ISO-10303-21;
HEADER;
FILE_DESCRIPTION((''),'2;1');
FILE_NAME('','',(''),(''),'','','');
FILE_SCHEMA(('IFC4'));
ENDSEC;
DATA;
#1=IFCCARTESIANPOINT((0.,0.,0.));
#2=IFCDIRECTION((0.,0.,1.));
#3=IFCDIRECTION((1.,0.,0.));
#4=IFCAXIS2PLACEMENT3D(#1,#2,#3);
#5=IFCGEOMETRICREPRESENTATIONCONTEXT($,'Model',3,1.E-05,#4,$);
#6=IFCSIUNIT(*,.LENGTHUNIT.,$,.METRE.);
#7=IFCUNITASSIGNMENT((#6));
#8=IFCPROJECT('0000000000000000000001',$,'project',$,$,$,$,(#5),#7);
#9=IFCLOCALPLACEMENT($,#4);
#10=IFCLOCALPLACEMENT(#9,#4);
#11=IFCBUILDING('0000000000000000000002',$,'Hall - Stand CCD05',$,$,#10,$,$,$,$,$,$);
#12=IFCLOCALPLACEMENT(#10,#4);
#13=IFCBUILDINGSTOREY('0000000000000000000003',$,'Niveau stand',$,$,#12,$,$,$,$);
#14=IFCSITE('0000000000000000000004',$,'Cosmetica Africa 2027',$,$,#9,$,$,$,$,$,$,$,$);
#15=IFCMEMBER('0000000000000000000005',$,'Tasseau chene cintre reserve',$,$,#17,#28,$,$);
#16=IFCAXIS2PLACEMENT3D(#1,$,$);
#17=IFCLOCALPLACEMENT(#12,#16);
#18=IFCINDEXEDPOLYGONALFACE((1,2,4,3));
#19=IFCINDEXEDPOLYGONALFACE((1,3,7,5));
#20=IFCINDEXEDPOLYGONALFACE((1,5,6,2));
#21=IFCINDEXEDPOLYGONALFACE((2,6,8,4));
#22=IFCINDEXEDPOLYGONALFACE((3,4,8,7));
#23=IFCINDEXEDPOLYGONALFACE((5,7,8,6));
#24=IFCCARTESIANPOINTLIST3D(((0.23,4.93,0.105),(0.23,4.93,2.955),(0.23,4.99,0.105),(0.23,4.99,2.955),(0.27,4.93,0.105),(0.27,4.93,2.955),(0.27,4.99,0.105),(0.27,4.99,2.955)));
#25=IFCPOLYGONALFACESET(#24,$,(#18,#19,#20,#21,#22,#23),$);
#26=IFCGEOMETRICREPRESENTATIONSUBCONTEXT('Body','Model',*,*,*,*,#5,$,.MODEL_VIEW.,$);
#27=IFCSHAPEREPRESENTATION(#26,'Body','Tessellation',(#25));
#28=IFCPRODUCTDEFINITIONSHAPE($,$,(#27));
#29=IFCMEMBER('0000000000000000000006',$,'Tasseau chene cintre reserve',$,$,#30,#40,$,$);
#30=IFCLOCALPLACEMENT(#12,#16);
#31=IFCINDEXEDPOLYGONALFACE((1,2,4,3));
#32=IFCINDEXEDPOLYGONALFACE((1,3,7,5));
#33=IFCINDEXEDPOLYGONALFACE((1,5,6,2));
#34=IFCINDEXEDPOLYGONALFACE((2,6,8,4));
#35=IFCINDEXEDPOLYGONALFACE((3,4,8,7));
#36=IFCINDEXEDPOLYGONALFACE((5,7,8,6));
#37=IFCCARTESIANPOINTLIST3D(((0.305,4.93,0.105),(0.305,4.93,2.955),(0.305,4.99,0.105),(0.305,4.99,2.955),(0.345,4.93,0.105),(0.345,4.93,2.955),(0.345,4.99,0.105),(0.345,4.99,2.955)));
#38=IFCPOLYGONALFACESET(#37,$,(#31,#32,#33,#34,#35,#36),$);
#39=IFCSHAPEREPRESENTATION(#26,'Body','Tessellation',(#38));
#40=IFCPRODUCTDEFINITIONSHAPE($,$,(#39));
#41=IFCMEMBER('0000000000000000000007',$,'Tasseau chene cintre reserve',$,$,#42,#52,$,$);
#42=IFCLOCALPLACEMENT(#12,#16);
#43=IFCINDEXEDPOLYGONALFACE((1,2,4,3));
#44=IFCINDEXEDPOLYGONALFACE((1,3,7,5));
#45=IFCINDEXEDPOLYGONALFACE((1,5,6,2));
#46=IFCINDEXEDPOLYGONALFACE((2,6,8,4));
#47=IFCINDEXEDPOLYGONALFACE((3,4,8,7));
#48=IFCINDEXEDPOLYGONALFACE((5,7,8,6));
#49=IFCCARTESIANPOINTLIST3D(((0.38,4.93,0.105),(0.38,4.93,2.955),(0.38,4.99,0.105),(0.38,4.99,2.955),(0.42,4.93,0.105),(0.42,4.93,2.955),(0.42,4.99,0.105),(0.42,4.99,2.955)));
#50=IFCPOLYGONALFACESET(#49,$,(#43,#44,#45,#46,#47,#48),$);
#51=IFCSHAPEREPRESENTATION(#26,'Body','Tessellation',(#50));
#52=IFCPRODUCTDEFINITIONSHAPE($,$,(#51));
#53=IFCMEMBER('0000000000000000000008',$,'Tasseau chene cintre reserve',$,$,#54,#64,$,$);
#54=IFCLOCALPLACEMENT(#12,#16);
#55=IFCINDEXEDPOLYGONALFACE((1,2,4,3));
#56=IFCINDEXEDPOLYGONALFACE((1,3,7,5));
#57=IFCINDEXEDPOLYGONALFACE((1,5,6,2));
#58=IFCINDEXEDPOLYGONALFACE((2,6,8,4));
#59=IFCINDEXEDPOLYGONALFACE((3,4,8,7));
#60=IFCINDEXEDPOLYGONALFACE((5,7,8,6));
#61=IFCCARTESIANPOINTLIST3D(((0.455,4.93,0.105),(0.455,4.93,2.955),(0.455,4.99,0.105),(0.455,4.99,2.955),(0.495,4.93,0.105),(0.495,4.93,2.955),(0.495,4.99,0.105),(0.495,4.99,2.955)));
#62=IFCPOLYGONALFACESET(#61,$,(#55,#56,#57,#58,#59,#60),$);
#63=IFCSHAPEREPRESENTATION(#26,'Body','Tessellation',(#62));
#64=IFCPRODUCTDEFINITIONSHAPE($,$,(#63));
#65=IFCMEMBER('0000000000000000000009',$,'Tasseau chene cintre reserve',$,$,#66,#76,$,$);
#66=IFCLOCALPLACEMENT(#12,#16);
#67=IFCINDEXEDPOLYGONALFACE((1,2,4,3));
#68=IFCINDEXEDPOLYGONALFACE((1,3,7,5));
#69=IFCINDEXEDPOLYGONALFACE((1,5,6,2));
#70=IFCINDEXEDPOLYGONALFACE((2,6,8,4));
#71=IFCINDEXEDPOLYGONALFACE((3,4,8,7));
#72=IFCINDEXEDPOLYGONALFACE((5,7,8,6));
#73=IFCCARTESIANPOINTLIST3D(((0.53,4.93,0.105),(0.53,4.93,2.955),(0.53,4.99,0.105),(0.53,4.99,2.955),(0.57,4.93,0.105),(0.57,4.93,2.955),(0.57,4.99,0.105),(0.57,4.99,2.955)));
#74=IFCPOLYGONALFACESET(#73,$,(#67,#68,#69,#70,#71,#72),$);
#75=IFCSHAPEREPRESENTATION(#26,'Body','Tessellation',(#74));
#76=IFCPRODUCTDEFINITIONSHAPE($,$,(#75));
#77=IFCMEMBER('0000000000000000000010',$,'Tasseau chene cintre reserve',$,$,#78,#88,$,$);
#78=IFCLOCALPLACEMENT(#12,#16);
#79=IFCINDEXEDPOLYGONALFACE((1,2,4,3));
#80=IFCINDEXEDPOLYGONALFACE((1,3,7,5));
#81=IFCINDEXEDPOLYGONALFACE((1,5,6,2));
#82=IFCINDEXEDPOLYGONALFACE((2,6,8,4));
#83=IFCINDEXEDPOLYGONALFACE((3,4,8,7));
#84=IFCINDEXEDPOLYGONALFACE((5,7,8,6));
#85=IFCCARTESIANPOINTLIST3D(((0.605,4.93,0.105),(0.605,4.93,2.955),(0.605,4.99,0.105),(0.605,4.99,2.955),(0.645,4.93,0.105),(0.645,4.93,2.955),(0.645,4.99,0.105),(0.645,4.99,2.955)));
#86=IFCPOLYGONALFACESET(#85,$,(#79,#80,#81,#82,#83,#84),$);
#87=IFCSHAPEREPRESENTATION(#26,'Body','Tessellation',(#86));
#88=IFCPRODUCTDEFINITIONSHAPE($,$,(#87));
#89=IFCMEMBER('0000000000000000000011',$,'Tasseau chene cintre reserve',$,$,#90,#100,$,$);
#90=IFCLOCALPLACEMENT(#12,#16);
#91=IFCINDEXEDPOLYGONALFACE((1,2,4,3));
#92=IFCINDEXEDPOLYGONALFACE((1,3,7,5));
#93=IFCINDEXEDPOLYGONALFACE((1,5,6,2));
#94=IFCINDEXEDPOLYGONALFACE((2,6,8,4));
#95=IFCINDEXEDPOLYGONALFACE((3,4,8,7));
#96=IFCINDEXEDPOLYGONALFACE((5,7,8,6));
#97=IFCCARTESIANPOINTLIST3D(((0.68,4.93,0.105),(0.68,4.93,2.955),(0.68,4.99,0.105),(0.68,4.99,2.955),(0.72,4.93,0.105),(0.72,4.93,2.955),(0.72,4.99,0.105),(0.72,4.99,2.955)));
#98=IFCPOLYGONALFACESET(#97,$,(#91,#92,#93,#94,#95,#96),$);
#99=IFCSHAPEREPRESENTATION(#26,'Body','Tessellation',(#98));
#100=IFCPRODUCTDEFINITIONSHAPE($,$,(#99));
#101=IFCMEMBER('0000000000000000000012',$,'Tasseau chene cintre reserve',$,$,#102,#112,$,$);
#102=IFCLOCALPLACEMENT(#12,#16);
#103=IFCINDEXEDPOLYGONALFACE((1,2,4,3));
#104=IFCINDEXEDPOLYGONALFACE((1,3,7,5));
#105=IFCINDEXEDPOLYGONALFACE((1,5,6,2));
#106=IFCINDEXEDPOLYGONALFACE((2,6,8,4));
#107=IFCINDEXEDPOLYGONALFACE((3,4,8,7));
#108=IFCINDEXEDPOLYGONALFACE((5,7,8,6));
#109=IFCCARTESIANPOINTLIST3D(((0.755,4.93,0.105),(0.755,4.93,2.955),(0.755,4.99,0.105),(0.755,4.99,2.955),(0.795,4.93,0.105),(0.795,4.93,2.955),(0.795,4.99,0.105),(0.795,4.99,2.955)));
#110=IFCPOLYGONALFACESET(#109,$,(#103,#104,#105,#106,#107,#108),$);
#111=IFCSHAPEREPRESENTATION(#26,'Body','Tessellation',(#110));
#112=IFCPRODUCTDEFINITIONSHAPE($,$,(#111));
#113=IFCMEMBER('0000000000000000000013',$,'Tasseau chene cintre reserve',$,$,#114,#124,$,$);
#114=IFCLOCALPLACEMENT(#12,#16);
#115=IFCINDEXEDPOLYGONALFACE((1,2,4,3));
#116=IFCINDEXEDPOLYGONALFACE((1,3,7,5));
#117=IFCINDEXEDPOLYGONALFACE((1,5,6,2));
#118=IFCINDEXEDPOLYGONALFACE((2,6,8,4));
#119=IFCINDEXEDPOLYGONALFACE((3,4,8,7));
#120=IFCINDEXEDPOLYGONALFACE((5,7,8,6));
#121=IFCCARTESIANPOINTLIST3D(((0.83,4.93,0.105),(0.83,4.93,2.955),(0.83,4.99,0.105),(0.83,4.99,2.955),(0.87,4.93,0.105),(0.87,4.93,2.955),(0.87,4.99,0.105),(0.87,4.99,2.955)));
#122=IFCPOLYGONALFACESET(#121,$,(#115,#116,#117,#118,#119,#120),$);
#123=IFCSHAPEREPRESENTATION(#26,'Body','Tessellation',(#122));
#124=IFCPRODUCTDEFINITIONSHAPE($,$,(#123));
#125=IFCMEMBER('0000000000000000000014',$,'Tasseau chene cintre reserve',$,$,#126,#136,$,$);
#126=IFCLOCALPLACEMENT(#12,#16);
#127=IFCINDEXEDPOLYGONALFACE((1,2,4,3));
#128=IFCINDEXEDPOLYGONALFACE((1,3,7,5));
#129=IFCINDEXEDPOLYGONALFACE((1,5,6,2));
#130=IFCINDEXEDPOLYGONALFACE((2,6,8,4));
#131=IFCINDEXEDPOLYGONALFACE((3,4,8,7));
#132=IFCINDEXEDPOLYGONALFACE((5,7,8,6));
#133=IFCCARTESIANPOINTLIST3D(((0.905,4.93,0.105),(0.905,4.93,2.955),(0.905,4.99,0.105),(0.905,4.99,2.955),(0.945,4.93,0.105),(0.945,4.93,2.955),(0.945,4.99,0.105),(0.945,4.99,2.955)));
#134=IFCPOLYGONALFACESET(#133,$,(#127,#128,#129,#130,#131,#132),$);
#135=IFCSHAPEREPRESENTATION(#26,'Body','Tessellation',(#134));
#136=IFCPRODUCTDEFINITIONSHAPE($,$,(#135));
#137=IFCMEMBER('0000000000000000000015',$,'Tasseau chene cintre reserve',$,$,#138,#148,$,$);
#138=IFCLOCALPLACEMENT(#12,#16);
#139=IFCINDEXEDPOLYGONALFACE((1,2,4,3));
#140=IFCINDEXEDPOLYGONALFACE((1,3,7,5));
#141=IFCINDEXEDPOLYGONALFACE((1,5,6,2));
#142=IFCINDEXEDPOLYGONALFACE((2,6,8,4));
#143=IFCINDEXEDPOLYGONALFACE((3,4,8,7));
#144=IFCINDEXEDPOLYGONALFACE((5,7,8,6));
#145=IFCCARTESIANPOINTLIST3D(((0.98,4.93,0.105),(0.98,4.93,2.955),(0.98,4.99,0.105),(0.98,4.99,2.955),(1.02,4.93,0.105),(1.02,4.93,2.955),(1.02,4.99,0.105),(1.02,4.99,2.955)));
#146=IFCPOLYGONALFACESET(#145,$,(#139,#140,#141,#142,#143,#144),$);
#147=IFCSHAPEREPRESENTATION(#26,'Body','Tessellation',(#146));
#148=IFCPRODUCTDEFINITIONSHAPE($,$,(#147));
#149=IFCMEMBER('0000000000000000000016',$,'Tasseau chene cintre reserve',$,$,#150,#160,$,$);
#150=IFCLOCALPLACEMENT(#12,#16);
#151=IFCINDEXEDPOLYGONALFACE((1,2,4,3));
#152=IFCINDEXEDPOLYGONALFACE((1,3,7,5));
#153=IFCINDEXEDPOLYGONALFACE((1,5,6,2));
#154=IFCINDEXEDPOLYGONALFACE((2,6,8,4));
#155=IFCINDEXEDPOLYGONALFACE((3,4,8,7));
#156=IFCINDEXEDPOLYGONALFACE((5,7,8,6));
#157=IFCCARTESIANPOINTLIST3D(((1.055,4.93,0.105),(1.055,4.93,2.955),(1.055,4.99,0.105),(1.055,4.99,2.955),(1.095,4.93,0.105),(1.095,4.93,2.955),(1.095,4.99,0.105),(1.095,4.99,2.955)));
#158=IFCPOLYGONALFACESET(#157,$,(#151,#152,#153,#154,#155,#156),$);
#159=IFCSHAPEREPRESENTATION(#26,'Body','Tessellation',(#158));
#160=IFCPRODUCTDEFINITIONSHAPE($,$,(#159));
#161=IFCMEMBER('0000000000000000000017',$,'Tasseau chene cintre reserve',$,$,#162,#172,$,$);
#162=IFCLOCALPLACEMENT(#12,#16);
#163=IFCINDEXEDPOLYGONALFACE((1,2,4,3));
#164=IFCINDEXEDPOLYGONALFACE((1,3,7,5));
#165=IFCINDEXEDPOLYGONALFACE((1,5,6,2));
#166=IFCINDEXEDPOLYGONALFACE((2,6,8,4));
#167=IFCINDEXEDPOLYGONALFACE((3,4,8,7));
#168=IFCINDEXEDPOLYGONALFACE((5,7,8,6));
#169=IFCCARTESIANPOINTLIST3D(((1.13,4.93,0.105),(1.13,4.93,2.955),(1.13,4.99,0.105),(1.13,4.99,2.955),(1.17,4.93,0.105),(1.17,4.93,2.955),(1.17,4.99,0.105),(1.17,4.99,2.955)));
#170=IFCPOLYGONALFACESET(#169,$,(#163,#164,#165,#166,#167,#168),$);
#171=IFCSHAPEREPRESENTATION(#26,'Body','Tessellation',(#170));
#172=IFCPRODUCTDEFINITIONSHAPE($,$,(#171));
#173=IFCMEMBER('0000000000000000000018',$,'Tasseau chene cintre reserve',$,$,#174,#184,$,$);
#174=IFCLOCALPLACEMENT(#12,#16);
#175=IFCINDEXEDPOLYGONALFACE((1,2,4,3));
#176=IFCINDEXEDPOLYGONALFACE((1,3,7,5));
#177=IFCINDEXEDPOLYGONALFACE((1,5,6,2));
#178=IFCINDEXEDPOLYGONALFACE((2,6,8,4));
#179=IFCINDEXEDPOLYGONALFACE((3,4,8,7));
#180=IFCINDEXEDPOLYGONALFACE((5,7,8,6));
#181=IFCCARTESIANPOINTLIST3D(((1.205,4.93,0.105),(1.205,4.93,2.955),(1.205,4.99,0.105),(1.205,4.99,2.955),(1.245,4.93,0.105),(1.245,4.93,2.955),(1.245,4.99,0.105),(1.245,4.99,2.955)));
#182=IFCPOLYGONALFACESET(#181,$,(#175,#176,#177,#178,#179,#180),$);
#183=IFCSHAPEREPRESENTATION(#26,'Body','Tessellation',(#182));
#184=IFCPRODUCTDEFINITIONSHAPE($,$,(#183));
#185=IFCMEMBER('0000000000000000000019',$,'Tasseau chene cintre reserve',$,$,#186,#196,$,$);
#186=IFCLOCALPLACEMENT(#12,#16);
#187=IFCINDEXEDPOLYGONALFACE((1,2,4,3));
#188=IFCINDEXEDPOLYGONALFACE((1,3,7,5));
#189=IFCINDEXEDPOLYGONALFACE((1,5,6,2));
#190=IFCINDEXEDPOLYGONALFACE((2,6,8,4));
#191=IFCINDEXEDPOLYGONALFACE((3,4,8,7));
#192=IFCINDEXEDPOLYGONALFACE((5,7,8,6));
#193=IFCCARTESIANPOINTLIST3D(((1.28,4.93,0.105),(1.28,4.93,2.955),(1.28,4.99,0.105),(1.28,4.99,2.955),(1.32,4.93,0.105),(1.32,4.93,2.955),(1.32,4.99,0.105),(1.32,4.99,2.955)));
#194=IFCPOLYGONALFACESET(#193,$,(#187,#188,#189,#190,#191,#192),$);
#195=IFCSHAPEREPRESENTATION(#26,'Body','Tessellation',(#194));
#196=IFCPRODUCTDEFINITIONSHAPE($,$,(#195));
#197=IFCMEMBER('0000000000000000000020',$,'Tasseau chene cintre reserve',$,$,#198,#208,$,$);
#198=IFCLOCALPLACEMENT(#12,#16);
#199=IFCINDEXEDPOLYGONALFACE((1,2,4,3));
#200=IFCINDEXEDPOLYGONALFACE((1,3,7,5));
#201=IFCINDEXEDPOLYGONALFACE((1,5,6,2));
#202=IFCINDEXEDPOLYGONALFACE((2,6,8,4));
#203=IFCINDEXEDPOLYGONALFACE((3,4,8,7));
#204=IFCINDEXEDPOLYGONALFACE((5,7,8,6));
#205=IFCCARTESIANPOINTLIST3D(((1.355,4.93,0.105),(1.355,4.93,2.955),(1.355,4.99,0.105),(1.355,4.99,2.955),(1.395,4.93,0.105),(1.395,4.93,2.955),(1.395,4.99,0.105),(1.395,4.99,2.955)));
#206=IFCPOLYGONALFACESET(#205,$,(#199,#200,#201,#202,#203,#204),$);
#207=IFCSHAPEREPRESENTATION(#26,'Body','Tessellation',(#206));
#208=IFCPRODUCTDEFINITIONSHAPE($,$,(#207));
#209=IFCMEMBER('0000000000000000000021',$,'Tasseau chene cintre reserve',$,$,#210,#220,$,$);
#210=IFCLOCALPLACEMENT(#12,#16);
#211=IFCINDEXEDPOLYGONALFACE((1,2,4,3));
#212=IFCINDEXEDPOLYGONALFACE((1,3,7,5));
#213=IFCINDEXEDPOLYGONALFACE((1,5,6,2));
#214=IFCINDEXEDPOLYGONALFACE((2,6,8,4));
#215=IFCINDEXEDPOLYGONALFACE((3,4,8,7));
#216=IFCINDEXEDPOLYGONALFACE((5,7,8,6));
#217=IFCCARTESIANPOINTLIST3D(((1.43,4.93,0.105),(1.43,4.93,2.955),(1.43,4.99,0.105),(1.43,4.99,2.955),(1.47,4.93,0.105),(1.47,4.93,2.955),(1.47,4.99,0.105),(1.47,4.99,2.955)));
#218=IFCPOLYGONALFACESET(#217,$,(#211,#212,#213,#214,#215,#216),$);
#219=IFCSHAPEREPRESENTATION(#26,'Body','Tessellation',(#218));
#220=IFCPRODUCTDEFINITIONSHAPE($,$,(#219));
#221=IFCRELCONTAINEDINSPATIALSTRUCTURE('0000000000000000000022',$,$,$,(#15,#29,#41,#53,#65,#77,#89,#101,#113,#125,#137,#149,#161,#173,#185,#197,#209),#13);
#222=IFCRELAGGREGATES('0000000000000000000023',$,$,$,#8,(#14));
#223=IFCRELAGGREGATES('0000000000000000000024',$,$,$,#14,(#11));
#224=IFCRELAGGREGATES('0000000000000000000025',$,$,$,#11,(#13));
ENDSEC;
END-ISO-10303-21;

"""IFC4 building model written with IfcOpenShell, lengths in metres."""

from ifc_helpers import new_model, si_unit, frame, origin_with_axes, place, context, subcontext, project, spatial, polyline, outline, extrude, element, save


model = new_model("IFC4")

# Units and contexts
model_context = context("Model", 3, precision=1e-05, world=origin_with_axes())
body_context = subcontext(model_context, "Body", "Model", "MODEL_VIEW")
ifc_project = project(units=[si_unit("LENGTHUNIT", "METRE")], contexts=[model_context])

# Site, building, storey
site_placement = place(None, origin_with_axes())
site = spatial("IfcSite", under=ifc_project, at=site_placement, Name="Cosmetica Africa 2027")
building_placement = place(site_placement, origin_with_axes())
building = spatial("IfcBuilding", under=site, at=building_placement, Name="Hall - Stand CCD05")
storey_placement = place(building_placement, origin_with_axes())
storey = spatial("IfcBuildingStorey", under=building, at=storey_placement, Name="Niveau stand")

# Members
member_1_placement = place(storey_placement, origin_with_axes())
element("IfcMember", 1, at=member_1_placement, inside=storey, Name="Tasseau chene cintre reserve", context=body_context, shape_type="SweptSolid", body=[
    extrude(outline(polyline([(0.23, 4.93), (0.27, 4.93), (0.27, 4.99), (0.23, 4.99), (0.23, 4.93)])), frame((0.0, 0.0, 0.105)), (0.0, 0.0, 1.0), 2.85),
])
member_2_placement = place(storey_placement, origin_with_axes())
element("IfcMember", 2, at=member_2_placement, inside=storey, Name="Tasseau chene cintre reserve", context=body_context, shape_type="SweptSolid", body=[
    extrude(outline(polyline([(0.305, 4.93), (0.345, 4.93), (0.345, 4.99), (0.305, 4.99), (0.305, 4.93)])), frame((0.0, 0.0, 0.105)), (0.0, 0.0, 1.0), 2.85),
])
member_3_placement = place(storey_placement, origin_with_axes())
element("IfcMember", 3, at=member_3_placement, inside=storey, Name="Tasseau chene cintre reserve", context=body_context, shape_type="SweptSolid", body=[
    extrude(outline(polyline([(0.38, 4.93), (0.42, 4.93), (0.42, 4.99), (0.38, 4.99), (0.38, 4.93)])), frame((0.0, 0.0, 0.105)), (0.0, 0.0, 1.0), 2.85),
])
member_4_placement = place(storey_placement, origin_with_axes())
element("IfcMember", 4, at=member_4_placement, inside=storey, Name="Tasseau chene cintre reserve", context=body_context, shape_type="SweptSolid", body=[
    extrude(outline(polyline([(0.455, 4.93), (0.495, 4.93), (0.495, 4.99), (0.455, 4.99), (0.455, 4.93)])), frame((0.0, 0.0, 0.105)), (0.0, 0.0, 1.0), 2.85),
])
member_5_placement = place(storey_placement, origin_with_axes())
element("IfcMember", 5, at=member_5_placement, inside=storey, Name="Tasseau chene cintre reserve", context=body_context, shape_type="SweptSolid", body=[
    extrude(outline(polyline([(0.53, 4.93), (0.57, 4.93), (0.57, 4.99), (0.53, 4.99), (0.53, 4.93)])), frame((0.0, 0.0, 0.105)), (0.0, 0.0, 1.0), 2.85),
])
member_6_placement = place(storey_placement, origin_with_axes())
element("IfcMember", 6, at=member_6_placement, inside=storey, Name="Tasseau chene cintre reserve", context=body_context, shape_type="SweptSolid", body=[
    extrude(outline(polyline([(0.605, 4.93), (0.645, 4.93), (0.645, 4.99), (0.605, 4.99), (0.605, 4.93)])), frame((0.0, 0.0, 0.105)), (0.0, 0.0, 1.0), 2.85),
])
member_7_placement = place(storey_placement, origin_with_axes())
element("IfcMember", 7, at=member_7_placement, inside=storey, Name="Tasseau chene cintre reserve", context=body_context, shape_type="SweptSolid", body=[
    extrude(outline(polyline([(0.68, 4.93), (0.72, 4.93), (0.72, 4.99), (0.68, 4.99), (0.68, 4.93)])), frame((0.0, 0.0, 0.105)), (0.0, 0.0, 1.0), 2.85),
])
member_8_placement = place(storey_placement, origin_with_axes())
element("IfcMember", 8, at=member_8_placement, inside=storey, Name="Tasseau chene cintre reserve", context=body_context, shape_type="SweptSolid", body=[
    extrude(outline(polyline([(0.755, 4.93), (0.795, 4.93), (0.795, 4.99), (0.755, 4.99), (0.755, 4.93)])), frame((0.0, 0.0, 0.105)), (0.0, 0.0, 1.0), 2.85),
])
member_9_placement = place(storey_placement, origin_with_axes())
element("IfcMember", 9, at=member_9_placement, inside=storey, Name="Tasseau chene cintre reserve", context=body_context, shape_type="SweptSolid", body=[
    extrude(outline(polyline([(0.83, 4.93), (0.87, 4.93), (0.87, 4.99), (0.83, 4.99), (0.83, 4.93)])), frame((0.0, 0.0, 0.105)), (0.0, 0.0, 1.0), 2.85),
])
member_10_placement = place(storey_placement, origin_with_axes())
element("IfcMember", 10, at=member_10_placement, inside=storey, Name="Tasseau chene cintre reserve", context=body_context, shape_type="SweptSolid", body=[
    extrude(outline(polyline([(0.905, 4.93), (0.945, 4.93), (0.945, 4.99), (0.905, 4.99), (0.905, 4.93)])), frame((0.0, 0.0, 0.105)), (0.0, 0.0, 1.0), 2.85),
])
member_11_placement = place(storey_placement, origin_with_axes())
element("IfcMember", 11, at=member_11_placement, inside=storey, Name="Tasseau chene cintre reserve", context=body_context, shape_type="SweptSolid", body=[
    extrude(outline(polyline([(0.98, 4.93), (1.02, 4.93), (1.02, 4.99), (0.98, 4.99), (0.98, 4.93)])), frame((0.0, 0.0, 0.105)), (0.0, 0.0, 1.0), 2.85),
])
member_12_placement = place(storey_placement, origin_with_axes())
element("IfcMember", 12, at=member_12_placement, inside=storey, Name="Tasseau chene cintre reserve", context=body_context, shape_type="SweptSolid", body=[
    extrude(outline(polyline([(1.055, 4.93), (1.095, 4.93), (1.095, 4.99), (1.055, 4.99), (1.055, 4.93)])), frame((0.0, 0.0, 0.105)), (0.0, 0.0, 1.0), 2.85),
])
member_13_placement = place(storey_placement, origin_with_axes())
element("IfcMember", 13, at=member_13_placement, inside=storey, Name="Tasseau chene cintre reserve", context=body_context, shape_type="SweptSolid", body=[
    extrude(outline(polyline([(1.13, 4.93), (1.17, 4.93), (1.17, 4.99), (1.13, 4.99), (1.13, 4.93)])), frame((0.0, 0.0, 0.105)), (0.0, 0.0, 1.0), 2.85),
])
member_14_placement = place(storey_placement, origin_with_axes())
element("IfcMember", 14, at=member_14_placement, inside=storey, Name="Tasseau chene cintre reserve", context=body_context, shape_type="SweptSolid", body=[
    extrude(outline(polyline([(1.205, 4.93), (1.245, 4.93), (1.245, 4.99), (1.205, 4.99), (1.205, 4.93)])), frame((0.0, 0.0, 0.105)), (0.0, 0.0, 1.0), 2.85),
])
member_15_placement = place(storey_placement, origin_with_axes())
element("IfcMember", 15, at=member_15_placement, inside=storey, Name="Tasseau chene cintre reserve", context=body_context, shape_type="SweptSolid", body=[
    extrude(outline(polyline([(1.28, 4.93), (1.32, 4.93), (1.32, 4.99), (1.28, 4.99), (1.28, 4.93)])), frame((0.0, 0.0, 0.105)), (0.0, 0.0, 1.0), 2.85),
])
member_16_placement = place(storey_placement, origin_with_axes())
element("IfcMember", 16, at=member_16_placement, inside=storey, Name="Tasseau chene cintre reserve", context=body_context, shape_type="SweptSolid", body=[
    extrude(outline(polyline([(1.355, 4.93), (1.395, 4.93), (1.395, 4.99), (1.355, 4.99), (1.355, 4.93)])), frame((0.0, 0.0, 0.105)), (0.0, 0.0, 1.0), 2.85),
])
member_17_placement = place(storey_placement, origin_with_axes())
element("IfcMember", 17, at=member_17_placement, inside=storey, Name="Tasseau chene cintre reserve", context=body_context, shape_type="SweptSolid", body=[
    extrude(outline(polyline([(1.43, 4.93), (1.47, 4.93), (1.47, 4.99), (1.43, 4.99), (1.43, 4.93)])), frame((0.0, 0.0, 0.105)), (0.0, 0.0, 1.0), 2.85),
])

save(model, "model.ifc")
